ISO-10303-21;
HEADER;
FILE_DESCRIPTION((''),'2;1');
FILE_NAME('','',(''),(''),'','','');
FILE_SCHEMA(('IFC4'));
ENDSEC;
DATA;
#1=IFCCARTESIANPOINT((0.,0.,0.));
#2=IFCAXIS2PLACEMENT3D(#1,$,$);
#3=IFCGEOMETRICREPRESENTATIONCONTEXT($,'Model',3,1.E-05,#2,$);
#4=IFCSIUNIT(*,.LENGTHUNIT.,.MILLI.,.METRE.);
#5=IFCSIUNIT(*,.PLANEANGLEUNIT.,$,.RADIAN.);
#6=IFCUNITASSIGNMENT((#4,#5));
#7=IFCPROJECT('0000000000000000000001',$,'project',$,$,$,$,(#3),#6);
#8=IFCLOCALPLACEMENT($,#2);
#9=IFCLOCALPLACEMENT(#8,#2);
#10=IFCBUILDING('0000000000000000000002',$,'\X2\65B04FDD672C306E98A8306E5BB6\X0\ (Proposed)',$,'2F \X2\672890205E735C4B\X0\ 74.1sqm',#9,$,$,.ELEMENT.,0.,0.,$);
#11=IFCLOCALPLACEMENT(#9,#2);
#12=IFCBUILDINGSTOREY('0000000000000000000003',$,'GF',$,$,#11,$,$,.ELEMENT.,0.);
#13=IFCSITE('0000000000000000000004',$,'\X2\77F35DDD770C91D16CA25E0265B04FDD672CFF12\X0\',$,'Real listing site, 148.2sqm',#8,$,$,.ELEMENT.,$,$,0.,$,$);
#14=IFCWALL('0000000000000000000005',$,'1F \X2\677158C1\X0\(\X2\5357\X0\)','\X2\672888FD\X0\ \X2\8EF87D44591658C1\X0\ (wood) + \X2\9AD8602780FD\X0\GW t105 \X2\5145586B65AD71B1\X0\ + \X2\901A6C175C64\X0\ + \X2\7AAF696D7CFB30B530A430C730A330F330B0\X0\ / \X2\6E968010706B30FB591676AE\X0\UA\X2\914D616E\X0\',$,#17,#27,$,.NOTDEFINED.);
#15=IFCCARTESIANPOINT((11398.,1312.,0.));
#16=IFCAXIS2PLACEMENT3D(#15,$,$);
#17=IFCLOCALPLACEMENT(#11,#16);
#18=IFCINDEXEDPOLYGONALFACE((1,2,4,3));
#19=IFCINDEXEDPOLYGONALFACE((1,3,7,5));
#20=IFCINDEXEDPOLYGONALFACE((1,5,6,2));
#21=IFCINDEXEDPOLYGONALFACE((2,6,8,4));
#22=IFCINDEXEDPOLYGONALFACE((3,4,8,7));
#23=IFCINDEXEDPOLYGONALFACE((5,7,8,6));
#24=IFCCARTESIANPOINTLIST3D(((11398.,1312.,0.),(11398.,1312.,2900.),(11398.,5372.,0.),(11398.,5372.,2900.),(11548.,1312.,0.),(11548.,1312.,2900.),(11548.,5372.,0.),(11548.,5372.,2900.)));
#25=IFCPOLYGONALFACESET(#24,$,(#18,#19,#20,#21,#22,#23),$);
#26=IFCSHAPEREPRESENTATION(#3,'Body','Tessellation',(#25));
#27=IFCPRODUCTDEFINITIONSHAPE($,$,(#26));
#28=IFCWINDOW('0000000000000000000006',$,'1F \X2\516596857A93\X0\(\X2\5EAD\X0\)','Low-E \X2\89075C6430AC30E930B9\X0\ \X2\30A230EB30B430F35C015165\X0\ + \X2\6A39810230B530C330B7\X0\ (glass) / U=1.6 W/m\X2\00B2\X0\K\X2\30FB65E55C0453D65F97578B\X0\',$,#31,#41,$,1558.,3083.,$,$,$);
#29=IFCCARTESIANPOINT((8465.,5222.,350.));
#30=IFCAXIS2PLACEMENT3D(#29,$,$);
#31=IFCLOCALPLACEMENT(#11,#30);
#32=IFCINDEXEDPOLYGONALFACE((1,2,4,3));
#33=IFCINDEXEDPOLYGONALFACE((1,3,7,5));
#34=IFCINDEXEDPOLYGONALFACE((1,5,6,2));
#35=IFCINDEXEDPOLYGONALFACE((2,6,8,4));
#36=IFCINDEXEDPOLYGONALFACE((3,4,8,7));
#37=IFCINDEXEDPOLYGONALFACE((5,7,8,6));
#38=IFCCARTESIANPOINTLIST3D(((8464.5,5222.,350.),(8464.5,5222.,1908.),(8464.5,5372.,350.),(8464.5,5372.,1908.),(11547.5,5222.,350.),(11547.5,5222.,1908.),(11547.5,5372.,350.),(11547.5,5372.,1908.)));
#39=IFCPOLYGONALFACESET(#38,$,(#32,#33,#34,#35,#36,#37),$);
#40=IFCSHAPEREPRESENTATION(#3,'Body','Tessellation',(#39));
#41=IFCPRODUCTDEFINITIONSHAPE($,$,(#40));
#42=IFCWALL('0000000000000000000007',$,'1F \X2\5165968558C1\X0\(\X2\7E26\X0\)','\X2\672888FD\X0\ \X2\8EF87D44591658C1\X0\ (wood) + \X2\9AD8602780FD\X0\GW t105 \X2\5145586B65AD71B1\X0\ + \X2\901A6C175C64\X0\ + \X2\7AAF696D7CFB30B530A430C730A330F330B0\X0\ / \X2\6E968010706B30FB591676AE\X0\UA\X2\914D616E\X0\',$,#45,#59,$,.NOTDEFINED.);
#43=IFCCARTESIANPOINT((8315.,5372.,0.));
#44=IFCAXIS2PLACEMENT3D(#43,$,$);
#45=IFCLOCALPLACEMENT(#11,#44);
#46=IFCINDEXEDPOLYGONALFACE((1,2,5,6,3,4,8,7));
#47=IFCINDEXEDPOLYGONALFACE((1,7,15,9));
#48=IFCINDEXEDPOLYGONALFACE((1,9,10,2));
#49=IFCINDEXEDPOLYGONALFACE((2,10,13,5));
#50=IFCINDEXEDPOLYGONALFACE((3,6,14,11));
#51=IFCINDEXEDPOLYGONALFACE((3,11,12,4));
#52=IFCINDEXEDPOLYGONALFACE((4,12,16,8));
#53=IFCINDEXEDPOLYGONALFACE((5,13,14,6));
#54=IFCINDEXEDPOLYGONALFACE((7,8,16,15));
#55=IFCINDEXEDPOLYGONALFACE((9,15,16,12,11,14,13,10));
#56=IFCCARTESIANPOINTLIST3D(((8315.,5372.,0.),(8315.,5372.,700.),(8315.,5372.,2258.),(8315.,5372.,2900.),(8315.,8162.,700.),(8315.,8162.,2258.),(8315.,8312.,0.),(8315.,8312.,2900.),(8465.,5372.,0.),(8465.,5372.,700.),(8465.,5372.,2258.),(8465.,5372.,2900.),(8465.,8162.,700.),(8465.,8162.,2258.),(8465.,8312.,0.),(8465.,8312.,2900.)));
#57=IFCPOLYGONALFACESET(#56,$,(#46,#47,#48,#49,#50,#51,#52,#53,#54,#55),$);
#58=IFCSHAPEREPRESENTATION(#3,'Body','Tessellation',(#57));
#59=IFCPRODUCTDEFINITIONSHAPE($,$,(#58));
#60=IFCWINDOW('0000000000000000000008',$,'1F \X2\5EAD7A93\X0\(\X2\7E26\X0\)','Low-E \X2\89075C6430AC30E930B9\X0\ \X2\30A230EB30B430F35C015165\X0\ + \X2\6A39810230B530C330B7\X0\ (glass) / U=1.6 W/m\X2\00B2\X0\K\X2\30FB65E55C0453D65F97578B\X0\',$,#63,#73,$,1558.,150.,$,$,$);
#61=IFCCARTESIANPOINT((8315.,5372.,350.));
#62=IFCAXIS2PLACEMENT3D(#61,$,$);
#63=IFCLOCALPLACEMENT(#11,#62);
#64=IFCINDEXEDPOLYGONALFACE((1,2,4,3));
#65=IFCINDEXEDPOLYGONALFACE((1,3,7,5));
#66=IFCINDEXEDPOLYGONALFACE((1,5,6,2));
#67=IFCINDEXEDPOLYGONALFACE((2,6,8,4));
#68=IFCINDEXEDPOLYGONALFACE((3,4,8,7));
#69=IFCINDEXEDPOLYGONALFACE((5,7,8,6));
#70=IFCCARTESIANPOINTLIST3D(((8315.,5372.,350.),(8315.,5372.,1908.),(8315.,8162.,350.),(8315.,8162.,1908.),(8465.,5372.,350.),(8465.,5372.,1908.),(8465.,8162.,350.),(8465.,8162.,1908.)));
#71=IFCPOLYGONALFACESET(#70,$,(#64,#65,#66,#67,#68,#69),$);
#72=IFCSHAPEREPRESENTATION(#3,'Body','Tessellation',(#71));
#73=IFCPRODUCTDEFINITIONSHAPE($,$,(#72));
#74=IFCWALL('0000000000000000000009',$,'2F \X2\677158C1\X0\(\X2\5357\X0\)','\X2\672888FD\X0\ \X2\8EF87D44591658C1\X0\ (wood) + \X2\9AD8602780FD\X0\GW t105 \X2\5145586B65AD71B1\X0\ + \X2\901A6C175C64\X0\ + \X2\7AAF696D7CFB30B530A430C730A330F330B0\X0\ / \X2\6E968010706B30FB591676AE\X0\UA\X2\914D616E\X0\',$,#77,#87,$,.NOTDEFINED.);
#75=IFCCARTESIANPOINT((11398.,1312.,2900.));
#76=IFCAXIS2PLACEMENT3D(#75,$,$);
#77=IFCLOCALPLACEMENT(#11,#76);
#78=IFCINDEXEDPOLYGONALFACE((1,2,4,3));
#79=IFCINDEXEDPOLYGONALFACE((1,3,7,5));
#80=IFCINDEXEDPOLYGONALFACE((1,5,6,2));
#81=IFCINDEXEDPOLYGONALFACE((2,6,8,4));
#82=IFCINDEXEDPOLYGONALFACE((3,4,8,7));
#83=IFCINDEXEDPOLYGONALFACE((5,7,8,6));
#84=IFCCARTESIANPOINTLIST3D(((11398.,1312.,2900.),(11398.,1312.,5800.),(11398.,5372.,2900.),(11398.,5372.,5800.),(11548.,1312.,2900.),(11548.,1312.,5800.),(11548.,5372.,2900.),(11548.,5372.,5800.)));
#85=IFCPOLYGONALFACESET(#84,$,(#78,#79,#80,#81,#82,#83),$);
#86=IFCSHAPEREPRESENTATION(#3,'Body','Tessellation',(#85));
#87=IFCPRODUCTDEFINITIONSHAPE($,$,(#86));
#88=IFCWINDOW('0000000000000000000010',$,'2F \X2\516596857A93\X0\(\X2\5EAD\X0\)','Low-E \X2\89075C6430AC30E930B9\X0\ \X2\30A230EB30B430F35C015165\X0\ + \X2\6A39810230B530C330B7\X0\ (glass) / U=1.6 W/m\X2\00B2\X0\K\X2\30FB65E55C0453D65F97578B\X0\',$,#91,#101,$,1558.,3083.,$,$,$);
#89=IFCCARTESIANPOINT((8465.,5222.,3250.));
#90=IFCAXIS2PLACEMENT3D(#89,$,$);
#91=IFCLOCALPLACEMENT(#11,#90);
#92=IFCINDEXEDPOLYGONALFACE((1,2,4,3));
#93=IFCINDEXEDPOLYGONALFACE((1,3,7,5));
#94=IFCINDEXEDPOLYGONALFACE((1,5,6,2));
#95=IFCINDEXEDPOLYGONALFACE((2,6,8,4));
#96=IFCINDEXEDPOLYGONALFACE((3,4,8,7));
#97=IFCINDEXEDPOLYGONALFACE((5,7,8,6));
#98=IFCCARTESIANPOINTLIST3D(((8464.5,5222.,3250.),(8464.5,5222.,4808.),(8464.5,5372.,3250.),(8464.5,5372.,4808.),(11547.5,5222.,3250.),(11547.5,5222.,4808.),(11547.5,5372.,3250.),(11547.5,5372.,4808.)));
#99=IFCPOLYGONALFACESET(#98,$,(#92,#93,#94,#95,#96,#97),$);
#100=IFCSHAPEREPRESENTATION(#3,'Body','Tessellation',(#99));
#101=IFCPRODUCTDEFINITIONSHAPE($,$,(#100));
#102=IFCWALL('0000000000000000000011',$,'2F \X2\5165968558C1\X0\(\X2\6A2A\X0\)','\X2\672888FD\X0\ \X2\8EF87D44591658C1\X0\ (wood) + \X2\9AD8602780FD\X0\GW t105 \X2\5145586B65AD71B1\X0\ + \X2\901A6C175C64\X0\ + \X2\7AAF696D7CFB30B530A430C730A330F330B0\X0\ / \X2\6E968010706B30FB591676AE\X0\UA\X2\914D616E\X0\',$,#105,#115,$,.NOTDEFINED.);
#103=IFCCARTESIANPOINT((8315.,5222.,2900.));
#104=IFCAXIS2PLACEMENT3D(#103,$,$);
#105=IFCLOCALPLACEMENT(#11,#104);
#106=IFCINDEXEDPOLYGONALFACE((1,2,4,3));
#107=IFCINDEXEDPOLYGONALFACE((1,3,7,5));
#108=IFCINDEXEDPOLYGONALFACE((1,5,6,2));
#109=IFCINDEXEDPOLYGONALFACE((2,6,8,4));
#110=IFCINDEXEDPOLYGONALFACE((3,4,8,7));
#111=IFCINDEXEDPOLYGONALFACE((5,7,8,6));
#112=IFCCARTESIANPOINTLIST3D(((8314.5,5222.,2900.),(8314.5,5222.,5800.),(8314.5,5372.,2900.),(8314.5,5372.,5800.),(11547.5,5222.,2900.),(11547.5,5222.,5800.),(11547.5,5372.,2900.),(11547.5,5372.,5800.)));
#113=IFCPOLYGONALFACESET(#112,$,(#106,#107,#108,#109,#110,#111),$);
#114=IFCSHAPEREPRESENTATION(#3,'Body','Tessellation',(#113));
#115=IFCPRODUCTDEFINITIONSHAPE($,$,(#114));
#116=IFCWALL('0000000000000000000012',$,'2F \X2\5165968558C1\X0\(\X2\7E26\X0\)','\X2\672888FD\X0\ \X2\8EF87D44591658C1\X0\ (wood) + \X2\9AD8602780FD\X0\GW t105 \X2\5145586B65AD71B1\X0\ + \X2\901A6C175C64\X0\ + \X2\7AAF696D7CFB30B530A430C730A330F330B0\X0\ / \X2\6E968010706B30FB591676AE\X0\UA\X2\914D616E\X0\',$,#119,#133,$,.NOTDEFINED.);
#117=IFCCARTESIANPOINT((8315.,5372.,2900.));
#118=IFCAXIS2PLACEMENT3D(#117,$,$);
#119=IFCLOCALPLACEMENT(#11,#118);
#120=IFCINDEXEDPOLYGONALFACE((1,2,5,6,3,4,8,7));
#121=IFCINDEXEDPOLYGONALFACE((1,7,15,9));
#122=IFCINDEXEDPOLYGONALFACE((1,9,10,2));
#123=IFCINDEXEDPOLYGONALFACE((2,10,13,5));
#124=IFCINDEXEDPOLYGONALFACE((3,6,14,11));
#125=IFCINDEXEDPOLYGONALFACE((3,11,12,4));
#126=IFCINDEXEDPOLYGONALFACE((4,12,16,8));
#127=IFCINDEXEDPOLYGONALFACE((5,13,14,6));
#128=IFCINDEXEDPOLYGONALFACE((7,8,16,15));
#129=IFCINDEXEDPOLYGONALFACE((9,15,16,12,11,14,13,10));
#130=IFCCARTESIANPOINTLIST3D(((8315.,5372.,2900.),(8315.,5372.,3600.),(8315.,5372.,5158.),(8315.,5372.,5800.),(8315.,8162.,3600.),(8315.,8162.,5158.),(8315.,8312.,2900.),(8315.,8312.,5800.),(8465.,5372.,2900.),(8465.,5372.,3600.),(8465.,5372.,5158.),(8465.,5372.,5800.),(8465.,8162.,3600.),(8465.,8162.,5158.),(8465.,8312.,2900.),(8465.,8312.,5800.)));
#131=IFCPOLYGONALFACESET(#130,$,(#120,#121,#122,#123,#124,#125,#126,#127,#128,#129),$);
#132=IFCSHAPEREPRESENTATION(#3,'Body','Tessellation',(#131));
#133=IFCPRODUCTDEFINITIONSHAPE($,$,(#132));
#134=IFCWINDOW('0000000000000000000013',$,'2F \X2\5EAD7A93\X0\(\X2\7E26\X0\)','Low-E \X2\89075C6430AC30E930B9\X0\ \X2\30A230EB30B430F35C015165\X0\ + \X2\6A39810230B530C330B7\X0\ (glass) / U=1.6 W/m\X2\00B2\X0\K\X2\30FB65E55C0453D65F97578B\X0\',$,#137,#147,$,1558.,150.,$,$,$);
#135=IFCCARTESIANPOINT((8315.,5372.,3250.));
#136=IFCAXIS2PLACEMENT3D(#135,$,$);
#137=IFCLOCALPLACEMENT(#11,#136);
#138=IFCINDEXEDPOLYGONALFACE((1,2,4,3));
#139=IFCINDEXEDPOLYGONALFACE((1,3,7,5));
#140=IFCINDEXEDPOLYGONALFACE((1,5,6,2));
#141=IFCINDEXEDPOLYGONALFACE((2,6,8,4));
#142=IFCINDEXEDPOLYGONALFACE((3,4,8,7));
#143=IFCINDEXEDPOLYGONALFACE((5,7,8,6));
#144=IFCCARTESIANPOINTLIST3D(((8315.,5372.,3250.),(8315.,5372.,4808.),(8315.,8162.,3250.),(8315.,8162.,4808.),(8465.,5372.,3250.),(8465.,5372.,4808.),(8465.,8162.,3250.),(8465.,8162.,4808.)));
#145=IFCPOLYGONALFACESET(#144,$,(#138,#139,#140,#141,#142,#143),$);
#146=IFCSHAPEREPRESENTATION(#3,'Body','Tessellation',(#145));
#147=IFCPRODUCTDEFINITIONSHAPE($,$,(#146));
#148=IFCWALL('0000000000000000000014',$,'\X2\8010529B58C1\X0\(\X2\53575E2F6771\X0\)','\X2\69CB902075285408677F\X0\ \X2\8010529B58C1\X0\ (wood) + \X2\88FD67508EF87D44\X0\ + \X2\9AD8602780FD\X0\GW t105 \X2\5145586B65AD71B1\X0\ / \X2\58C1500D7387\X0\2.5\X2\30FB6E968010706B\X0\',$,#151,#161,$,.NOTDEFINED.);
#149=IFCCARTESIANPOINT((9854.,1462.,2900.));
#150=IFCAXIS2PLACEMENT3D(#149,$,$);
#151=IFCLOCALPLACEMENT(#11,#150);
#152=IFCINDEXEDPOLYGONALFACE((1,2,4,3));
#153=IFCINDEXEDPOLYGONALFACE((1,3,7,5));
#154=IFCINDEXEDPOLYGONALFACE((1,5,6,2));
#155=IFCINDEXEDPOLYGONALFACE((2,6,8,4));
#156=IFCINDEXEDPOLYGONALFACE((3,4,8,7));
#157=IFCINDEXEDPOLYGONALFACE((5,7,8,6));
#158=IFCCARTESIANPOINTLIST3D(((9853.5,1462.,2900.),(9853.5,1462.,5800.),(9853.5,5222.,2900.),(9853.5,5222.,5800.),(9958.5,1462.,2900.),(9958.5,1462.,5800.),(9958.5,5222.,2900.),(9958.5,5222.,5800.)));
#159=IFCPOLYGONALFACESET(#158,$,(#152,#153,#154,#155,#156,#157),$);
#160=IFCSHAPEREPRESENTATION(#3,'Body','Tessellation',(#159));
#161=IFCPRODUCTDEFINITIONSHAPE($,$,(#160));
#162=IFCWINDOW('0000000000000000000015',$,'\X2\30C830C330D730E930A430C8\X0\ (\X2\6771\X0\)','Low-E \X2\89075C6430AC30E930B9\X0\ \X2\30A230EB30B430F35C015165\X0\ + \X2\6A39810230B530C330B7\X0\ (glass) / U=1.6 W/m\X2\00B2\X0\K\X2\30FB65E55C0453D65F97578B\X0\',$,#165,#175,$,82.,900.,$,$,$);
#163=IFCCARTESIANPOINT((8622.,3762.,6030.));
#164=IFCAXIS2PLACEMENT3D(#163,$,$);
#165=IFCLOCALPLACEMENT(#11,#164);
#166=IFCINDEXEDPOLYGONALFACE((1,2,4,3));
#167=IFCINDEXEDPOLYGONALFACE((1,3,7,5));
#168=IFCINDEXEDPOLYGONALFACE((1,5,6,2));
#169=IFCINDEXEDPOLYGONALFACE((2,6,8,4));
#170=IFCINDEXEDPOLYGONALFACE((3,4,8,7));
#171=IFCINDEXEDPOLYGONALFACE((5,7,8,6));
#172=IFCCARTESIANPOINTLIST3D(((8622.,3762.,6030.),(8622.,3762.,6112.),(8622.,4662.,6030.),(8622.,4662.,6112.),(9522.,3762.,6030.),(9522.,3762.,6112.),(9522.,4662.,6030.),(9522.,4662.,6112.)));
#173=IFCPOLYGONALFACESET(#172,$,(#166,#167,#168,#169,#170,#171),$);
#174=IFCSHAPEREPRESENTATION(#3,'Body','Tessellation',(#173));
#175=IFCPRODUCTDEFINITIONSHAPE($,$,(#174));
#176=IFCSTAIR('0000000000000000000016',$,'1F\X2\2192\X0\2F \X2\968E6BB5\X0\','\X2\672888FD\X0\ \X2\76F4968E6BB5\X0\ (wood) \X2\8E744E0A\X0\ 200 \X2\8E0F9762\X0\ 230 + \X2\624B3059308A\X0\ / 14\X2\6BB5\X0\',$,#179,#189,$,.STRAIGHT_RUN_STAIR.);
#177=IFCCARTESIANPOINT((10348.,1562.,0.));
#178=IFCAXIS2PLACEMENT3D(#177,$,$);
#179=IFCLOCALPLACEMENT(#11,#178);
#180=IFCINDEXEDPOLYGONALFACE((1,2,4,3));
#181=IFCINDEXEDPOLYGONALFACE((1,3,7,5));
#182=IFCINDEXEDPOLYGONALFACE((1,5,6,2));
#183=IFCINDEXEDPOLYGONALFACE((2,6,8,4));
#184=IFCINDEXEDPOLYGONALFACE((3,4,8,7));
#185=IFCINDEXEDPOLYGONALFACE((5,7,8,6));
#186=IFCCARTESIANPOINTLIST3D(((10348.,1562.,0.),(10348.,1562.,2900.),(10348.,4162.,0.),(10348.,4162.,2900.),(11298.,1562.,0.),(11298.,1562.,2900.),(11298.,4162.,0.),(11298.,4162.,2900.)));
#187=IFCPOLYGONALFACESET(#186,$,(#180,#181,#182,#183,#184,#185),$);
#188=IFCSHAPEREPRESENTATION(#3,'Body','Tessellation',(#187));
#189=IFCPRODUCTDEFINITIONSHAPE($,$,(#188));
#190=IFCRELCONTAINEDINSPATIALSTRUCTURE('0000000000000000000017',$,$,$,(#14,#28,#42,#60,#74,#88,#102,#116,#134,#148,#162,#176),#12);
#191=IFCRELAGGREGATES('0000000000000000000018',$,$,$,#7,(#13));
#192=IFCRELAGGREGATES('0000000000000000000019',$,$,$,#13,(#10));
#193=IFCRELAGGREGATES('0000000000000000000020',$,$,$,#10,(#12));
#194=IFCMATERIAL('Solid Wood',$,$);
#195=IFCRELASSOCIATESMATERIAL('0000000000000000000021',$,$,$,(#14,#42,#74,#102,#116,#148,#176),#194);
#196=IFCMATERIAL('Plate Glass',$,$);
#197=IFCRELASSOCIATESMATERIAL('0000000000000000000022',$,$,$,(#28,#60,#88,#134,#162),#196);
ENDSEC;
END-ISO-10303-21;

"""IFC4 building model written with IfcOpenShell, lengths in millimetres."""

from ifc_helpers import new_model, si_unit, frame, frame_2d, origin, place, context, project, spatial, rectangle, extrude, material, element, fill, save


model = new_model("IFC4")

# Units and contexts
model_context = context("Model", 3, precision=1e-05, world=origin())
ifc_project = project(units=[si_unit("LENGTHUNIT", "METRE", prefix="MILLI"), si_unit("PLANEANGLEUNIT", "RADIAN")], contexts=[model_context])

# Site, building, storey
site_placement = place(None, origin())
site = spatial("IfcSite", under=ifc_project, at=site_placement, Name="石川県金沢市新保本２", ObjectType="Real listing site, 148.2sqm", CompositionType="ELEMENT", RefElevation=0.0)
building_placement = place(site_placement, origin())
building = spatial("IfcBuilding", under=site, at=building_placement, Name="新保本の風の家 (Proposed)", ObjectType="2F 木造平屋 74.1sqm", CompositionType="ELEMENT", ElevationOfRefHeight=0.0, ElevationOfTerrain=0.0)
storey_placement = place(building_placement, origin())
storey = spatial("IfcBuildingStorey", under=building, at=storey_placement, Name="GF", CompositionType="ELEMENT", Elevation=0.0)

# Shared definitions
ifc_material_1 = material(Name="Solid Wood")

# Wall, opening, window
wall_1_placement = place(storey_placement, frame((11398.0, 1312.0, 0.0)))
wall_1 = element("IfcWall", 1, at=wall_1_placement, inside=storey, material=ifc_material_1, Name="1F 東壁(南)", Description="木製 軸組外壁 (wood) + 高性能GW t105 充填断熱 + 通気層 + 窯業系サイディング / 準耐火・外皮UA配慮", PredefinedType="NOTDEFINED", context=model_context, shape_type="SweptSolid", body=[
    extrude(rectangle(XDim=150.0, YDim=4060.0, at=frame_2d((75.0, 2030.0))), frame((11398.0, 1312.0, 0.0)), (0.0, 0.0, 1.0), 2900.0),
])
opening_1_placement = place(storey_placement, frame((8465.0, 5222.0, 350.0)))
opening_1 = element("IfcOpeningElement", 2, at=opening_1_placement, cuts=wall_1, PredefinedType="NOTDEFINED", context=model_context, shape_type="SweptSolid", body=[
    extrude(rectangle(XDim=3083.0, YDim=150.0, at=frame_2d((1541.0, 75.0))), frame((8465.0, 5222.0, 350.0)), (0.0, 0.0, 1.0), 1558.0),
])
ifc_material_2 = material(Name="Plate Glass")
window_1_placement = place(storey_placement, frame((8465.0, 5222.0, 350.0)))
window_1 = element("IfcWindow", 3, at=window_1_placement, inside=storey, material=ifc_material_2, Name="1F 入隅窓(庭)", Description="Low-E 複層ガラス アルゴン封入 + 樹脂サッシ (glass) / U=1.6 W/m²K・日射取得型", OverallHeight=1558.0, OverallWidth=3083.0, context=model_context, shape_type="SweptSolid", body=[
    extrude(rectangle(XDim=3083.0, YDim=150.0, at=frame_2d((1541.0, 75.0))), frame((8465.0, 5222.0, 350.0)), (0.0, 0.0, 1.0), 1558.0),
])
fill(opening_1, window_1)

# Wall, opening, window
wall_2_placement = place(storey_placement, frame((8315.0, 5372.0, 0.0)))
wall_2 = element("IfcWall", 4, at=wall_2_placement, inside=storey, material=ifc_material_1, Name="1F 入隅壁(縦)", Description="木製 軸組外壁 (wood) + 高性能GW t105 充填断熱 + 通気層 + 窯業系サイディング / 準耐火・外皮UA配慮", PredefinedType="NOTDEFINED", context=model_context, shape_type="SweptSolid", body=[
    extrude(rectangle(XDim=150.0, YDim=2940.0, at=frame_2d((75.0, 1470.0))), frame((8315.0, 5372.0, 0.0)), (0.0, 0.0, 1.0), 2900.0),
])
opening_2_placement = place(storey_placement, frame((8315.0, 5372.0, 350.0)))
opening_2 = element("IfcOpeningElement", 5, at=opening_2_placement, cuts=wall_2, PredefinedType="NOTDEFINED", context=model_context, shape_type="SweptSolid", body=[
    extrude(rectangle(XDim=150.0, YDim=2790.0, at=frame_2d((75.0, 1395.0))), frame((8315.0, 5372.0, 350.0)), (0.0, 0.0, 1.0), 1558.0),
])
window_2_placement = place(storey_placement, frame((8315.0, 5372.0, 350.0)))
window_2 = element("IfcWindow", 6, at=window_2_placement, inside=storey, material=ifc_material_2, Name="1F 庭窓(縦)", Description="Low-E 複層ガラス アルゴン封入 + 樹脂サッシ (glass) / U=1.6 W/m²K・日射取得型", OverallHeight=1558.0, OverallWidth=150.0, context=model_context, shape_type="SweptSolid", body=[
    extrude(rectangle(XDim=150.0, YDim=2790.0, at=frame_2d((75.0, 1395.0))), frame((8315.0, 5372.0, 350.0)), (0.0, 0.0, 1.0), 1558.0),
])
fill(opening_2, window_2)

# Wall, opening, window
wall_3_placement = place(storey_placement, frame((11398.0, 1312.0, 2900.0)))
wall_3 = element("IfcWall", 7, at=wall_3_placement, inside=storey, material=ifc_material_1, Name="2F 東壁(南)", Description="木製 軸組外壁 (wood) + 高性能GW t105 充填断熱 + 通気層 + 窯業系サイディング / 準耐火・外皮UA配慮", PredefinedType="NOTDEFINED", context=model_context, shape_type="SweptSolid", body=[
    extrude(rectangle(XDim=150.0, YDim=4060.0, at=frame_2d((75.0, 2030.0))), frame((11398.0, 1312.0, 2900.0)), (0.0, 0.0, 1.0), 2900.0),
])
opening_3_placement = place(storey_placement, frame((8465.0, 5222.0, 3250.0)))
opening_3 = element("IfcOpeningElement", 8, at=opening_3_placement, cuts=wall_3, PredefinedType="NOTDEFINED", context=model_context, shape_type="SweptSolid", body=[
    extrude(rectangle(XDim=3083.0, YDim=150.0, at=frame_2d((1541.0, 75.0))), frame((8465.0, 5222.0, 3250.0)), (0.0, 0.0, 1.0), 1558.0),
])
window_3_placement = place(storey_placement, frame((8465.0, 5222.0, 3250.0)))
window_3 = element("IfcWindow", 9, at=window_3_placement, inside=storey, material=ifc_material_2, Name="2F 入隅窓(庭)", Description="Low-E 複層ガラス アルゴン封入 + 樹脂サッシ (glass) / U=1.6 W/m²K・日射取得型", OverallHeight=1558.0, OverallWidth=3083.0, context=model_context, shape_type="SweptSolid", body=[
    extrude(rectangle(XDim=3083.0, YDim=150.0, at=frame_2d((1541.0, 75.0))), frame((8465.0, 5222.0, 3250.0)), (0.0, 0.0, 1.0), 1558.0),
])
fill(opening_3, window_3)

# Wall
wall_4_placement = place(storey_placement, frame((8315.0, 5222.0, 2900.0)))
element("IfcWall", 10, at=wall_4_placement, inside=storey, material=ifc_material_1, Name="2F 入隅壁(横)", Description="木製 軸組外壁 (wood) + 高性能GW t105 充填断熱 + 通気層 + 窯業系サイディング / 準耐火・外皮UA配慮", PredefinedType="NOTDEFINED", context=model_context, shape_type="SweptSolid", body=[
    extrude(rectangle(XDim=3233.0, YDim=150.0, at=frame_2d((1616.0, 75.0))), frame((8315.0, 5222.0, 2900.0)), (0.0, 0.0, 1.0), 2900.0),
])

# Wall, opening, window
wall_5_placement = place(storey_placement, frame((8315.0, 5372.0, 2900.0)))
wall_5 = element("IfcWall", 11, at=wall_5_placement, inside=storey, material=ifc_material_1, Name="2F 入隅壁(縦)", Description="木製 軸組外壁 (wood) + 高性能GW t105 充填断熱 + 通気層 + 窯業系サイディング / 準耐火・外皮UA配慮", PredefinedType="NOTDEFINED", context=model_context, shape_type="SweptSolid", body=[
    extrude(rectangle(XDim=150.0, YDim=2940.0, at=frame_2d((75.0, 1470.0))), frame((8315.0, 5372.0, 2900.0)), (0.0, 0.0, 1.0), 2900.0),
])
opening_4_placement = place(storey_placement, frame((8315.0, 5372.0, 3250.0)))
opening_4 = element("IfcOpeningElement", 12, at=opening_4_placement, cuts=wall_5, PredefinedType="NOTDEFINED", context=model_context, shape_type="SweptSolid", body=[
    extrude(rectangle(XDim=150.0, YDim=2790.0, at=frame_2d((75.0, 1395.0))), frame((8315.0, 5372.0, 3250.0)), (0.0, 0.0, 1.0), 1558.0),
])
window_4_placement = place(storey_placement, frame((8315.0, 5372.0, 3250.0)))
window_4 = element("IfcWindow", 13, at=window_4_placement, inside=storey, material=ifc_material_2, Name="2F 庭窓(縦)", Description="Low-E 複層ガラス アルゴン封入 + 樹脂サッシ (glass) / U=1.6 W/m²K・日射取得型", OverallHeight=1558.0, OverallWidth=150.0, context=model_context, shape_type="SweptSolid", body=[
    extrude(rectangle(XDim=150.0, YDim=2790.0, at=frame_2d((75.0, 1395.0))), frame((8315.0, 5372.0, 3250.0)), (0.0, 0.0, 1.0), 1558.0),
])
fill(opening_4, window_4)

# Wall
wall_6_placement = place(storey_placement, frame((9854.0, 1462.0, 2900.0)))
element("IfcWall", 14, at=wall_6_placement, inside=storey, material=ifc_material_1, Name="耐力壁(南帯東)", Description="構造用合板 耐力壁 (wood) + 製材軸組 + 高性能GW t105 充填断熱 / 壁倍率2.5・準耐火", PredefinedType="NOTDEFINED", context=model_context, shape_type="SweptSolid", body=[
    extrude(rectangle(XDim=105.0, YDim=3760.0, at=frame_2d((52.0, 1880.0))), frame((9854.0, 1462.0, 2900.0)), (0.0, 0.0, 1.0), 2900.0),
])

# Window
window_5_placement = place(storey_placement, frame((8622.0, 3762.0, 6030.0)))
element("IfcWindow", 15, at=window_5_placement, inside=storey, material=ifc_material_2, Name="トップライト (東)", Description="Low-E 複層ガラス アルゴン封入 + 樹脂サッシ (glass) / U=1.6 W/m²K・日射取得型", OverallHeight=82.0, OverallWidth=900.0, context=model_context, shape_type="SweptSolid", body=[
    extrude(rectangle(XDim=900.0, YDim=900.0, at=frame_2d((450.0, 450.0))), frame((8622.0, 3762.0, 6030.0)), (0.0, 0.0, 1.0), 82.0),
])

# Stair
stair_placement = place(storey_placement, frame((10348.0, 1562.0, 0.0)))
element("IfcStair", 16, at=stair_placement, inside=storey, material=ifc_material_1, Name="1F→2F 階段", Description="木製 直階段 (wood) 蹴上 200 踏面 230 + 手すり / 14段", PredefinedType="STRAIGHT_RUN_STAIR", context=model_context, shape_type="SweptSolid", body=[
    extrude(rectangle(XDim=950.0, YDim=2600.0, at=frame_2d((475.0, 1300.0))), frame((10348.0, 1562.0, 0.0)), (0.0, 0.0, 1.0), 2900.0),
])

save(model, "model.ifc")
